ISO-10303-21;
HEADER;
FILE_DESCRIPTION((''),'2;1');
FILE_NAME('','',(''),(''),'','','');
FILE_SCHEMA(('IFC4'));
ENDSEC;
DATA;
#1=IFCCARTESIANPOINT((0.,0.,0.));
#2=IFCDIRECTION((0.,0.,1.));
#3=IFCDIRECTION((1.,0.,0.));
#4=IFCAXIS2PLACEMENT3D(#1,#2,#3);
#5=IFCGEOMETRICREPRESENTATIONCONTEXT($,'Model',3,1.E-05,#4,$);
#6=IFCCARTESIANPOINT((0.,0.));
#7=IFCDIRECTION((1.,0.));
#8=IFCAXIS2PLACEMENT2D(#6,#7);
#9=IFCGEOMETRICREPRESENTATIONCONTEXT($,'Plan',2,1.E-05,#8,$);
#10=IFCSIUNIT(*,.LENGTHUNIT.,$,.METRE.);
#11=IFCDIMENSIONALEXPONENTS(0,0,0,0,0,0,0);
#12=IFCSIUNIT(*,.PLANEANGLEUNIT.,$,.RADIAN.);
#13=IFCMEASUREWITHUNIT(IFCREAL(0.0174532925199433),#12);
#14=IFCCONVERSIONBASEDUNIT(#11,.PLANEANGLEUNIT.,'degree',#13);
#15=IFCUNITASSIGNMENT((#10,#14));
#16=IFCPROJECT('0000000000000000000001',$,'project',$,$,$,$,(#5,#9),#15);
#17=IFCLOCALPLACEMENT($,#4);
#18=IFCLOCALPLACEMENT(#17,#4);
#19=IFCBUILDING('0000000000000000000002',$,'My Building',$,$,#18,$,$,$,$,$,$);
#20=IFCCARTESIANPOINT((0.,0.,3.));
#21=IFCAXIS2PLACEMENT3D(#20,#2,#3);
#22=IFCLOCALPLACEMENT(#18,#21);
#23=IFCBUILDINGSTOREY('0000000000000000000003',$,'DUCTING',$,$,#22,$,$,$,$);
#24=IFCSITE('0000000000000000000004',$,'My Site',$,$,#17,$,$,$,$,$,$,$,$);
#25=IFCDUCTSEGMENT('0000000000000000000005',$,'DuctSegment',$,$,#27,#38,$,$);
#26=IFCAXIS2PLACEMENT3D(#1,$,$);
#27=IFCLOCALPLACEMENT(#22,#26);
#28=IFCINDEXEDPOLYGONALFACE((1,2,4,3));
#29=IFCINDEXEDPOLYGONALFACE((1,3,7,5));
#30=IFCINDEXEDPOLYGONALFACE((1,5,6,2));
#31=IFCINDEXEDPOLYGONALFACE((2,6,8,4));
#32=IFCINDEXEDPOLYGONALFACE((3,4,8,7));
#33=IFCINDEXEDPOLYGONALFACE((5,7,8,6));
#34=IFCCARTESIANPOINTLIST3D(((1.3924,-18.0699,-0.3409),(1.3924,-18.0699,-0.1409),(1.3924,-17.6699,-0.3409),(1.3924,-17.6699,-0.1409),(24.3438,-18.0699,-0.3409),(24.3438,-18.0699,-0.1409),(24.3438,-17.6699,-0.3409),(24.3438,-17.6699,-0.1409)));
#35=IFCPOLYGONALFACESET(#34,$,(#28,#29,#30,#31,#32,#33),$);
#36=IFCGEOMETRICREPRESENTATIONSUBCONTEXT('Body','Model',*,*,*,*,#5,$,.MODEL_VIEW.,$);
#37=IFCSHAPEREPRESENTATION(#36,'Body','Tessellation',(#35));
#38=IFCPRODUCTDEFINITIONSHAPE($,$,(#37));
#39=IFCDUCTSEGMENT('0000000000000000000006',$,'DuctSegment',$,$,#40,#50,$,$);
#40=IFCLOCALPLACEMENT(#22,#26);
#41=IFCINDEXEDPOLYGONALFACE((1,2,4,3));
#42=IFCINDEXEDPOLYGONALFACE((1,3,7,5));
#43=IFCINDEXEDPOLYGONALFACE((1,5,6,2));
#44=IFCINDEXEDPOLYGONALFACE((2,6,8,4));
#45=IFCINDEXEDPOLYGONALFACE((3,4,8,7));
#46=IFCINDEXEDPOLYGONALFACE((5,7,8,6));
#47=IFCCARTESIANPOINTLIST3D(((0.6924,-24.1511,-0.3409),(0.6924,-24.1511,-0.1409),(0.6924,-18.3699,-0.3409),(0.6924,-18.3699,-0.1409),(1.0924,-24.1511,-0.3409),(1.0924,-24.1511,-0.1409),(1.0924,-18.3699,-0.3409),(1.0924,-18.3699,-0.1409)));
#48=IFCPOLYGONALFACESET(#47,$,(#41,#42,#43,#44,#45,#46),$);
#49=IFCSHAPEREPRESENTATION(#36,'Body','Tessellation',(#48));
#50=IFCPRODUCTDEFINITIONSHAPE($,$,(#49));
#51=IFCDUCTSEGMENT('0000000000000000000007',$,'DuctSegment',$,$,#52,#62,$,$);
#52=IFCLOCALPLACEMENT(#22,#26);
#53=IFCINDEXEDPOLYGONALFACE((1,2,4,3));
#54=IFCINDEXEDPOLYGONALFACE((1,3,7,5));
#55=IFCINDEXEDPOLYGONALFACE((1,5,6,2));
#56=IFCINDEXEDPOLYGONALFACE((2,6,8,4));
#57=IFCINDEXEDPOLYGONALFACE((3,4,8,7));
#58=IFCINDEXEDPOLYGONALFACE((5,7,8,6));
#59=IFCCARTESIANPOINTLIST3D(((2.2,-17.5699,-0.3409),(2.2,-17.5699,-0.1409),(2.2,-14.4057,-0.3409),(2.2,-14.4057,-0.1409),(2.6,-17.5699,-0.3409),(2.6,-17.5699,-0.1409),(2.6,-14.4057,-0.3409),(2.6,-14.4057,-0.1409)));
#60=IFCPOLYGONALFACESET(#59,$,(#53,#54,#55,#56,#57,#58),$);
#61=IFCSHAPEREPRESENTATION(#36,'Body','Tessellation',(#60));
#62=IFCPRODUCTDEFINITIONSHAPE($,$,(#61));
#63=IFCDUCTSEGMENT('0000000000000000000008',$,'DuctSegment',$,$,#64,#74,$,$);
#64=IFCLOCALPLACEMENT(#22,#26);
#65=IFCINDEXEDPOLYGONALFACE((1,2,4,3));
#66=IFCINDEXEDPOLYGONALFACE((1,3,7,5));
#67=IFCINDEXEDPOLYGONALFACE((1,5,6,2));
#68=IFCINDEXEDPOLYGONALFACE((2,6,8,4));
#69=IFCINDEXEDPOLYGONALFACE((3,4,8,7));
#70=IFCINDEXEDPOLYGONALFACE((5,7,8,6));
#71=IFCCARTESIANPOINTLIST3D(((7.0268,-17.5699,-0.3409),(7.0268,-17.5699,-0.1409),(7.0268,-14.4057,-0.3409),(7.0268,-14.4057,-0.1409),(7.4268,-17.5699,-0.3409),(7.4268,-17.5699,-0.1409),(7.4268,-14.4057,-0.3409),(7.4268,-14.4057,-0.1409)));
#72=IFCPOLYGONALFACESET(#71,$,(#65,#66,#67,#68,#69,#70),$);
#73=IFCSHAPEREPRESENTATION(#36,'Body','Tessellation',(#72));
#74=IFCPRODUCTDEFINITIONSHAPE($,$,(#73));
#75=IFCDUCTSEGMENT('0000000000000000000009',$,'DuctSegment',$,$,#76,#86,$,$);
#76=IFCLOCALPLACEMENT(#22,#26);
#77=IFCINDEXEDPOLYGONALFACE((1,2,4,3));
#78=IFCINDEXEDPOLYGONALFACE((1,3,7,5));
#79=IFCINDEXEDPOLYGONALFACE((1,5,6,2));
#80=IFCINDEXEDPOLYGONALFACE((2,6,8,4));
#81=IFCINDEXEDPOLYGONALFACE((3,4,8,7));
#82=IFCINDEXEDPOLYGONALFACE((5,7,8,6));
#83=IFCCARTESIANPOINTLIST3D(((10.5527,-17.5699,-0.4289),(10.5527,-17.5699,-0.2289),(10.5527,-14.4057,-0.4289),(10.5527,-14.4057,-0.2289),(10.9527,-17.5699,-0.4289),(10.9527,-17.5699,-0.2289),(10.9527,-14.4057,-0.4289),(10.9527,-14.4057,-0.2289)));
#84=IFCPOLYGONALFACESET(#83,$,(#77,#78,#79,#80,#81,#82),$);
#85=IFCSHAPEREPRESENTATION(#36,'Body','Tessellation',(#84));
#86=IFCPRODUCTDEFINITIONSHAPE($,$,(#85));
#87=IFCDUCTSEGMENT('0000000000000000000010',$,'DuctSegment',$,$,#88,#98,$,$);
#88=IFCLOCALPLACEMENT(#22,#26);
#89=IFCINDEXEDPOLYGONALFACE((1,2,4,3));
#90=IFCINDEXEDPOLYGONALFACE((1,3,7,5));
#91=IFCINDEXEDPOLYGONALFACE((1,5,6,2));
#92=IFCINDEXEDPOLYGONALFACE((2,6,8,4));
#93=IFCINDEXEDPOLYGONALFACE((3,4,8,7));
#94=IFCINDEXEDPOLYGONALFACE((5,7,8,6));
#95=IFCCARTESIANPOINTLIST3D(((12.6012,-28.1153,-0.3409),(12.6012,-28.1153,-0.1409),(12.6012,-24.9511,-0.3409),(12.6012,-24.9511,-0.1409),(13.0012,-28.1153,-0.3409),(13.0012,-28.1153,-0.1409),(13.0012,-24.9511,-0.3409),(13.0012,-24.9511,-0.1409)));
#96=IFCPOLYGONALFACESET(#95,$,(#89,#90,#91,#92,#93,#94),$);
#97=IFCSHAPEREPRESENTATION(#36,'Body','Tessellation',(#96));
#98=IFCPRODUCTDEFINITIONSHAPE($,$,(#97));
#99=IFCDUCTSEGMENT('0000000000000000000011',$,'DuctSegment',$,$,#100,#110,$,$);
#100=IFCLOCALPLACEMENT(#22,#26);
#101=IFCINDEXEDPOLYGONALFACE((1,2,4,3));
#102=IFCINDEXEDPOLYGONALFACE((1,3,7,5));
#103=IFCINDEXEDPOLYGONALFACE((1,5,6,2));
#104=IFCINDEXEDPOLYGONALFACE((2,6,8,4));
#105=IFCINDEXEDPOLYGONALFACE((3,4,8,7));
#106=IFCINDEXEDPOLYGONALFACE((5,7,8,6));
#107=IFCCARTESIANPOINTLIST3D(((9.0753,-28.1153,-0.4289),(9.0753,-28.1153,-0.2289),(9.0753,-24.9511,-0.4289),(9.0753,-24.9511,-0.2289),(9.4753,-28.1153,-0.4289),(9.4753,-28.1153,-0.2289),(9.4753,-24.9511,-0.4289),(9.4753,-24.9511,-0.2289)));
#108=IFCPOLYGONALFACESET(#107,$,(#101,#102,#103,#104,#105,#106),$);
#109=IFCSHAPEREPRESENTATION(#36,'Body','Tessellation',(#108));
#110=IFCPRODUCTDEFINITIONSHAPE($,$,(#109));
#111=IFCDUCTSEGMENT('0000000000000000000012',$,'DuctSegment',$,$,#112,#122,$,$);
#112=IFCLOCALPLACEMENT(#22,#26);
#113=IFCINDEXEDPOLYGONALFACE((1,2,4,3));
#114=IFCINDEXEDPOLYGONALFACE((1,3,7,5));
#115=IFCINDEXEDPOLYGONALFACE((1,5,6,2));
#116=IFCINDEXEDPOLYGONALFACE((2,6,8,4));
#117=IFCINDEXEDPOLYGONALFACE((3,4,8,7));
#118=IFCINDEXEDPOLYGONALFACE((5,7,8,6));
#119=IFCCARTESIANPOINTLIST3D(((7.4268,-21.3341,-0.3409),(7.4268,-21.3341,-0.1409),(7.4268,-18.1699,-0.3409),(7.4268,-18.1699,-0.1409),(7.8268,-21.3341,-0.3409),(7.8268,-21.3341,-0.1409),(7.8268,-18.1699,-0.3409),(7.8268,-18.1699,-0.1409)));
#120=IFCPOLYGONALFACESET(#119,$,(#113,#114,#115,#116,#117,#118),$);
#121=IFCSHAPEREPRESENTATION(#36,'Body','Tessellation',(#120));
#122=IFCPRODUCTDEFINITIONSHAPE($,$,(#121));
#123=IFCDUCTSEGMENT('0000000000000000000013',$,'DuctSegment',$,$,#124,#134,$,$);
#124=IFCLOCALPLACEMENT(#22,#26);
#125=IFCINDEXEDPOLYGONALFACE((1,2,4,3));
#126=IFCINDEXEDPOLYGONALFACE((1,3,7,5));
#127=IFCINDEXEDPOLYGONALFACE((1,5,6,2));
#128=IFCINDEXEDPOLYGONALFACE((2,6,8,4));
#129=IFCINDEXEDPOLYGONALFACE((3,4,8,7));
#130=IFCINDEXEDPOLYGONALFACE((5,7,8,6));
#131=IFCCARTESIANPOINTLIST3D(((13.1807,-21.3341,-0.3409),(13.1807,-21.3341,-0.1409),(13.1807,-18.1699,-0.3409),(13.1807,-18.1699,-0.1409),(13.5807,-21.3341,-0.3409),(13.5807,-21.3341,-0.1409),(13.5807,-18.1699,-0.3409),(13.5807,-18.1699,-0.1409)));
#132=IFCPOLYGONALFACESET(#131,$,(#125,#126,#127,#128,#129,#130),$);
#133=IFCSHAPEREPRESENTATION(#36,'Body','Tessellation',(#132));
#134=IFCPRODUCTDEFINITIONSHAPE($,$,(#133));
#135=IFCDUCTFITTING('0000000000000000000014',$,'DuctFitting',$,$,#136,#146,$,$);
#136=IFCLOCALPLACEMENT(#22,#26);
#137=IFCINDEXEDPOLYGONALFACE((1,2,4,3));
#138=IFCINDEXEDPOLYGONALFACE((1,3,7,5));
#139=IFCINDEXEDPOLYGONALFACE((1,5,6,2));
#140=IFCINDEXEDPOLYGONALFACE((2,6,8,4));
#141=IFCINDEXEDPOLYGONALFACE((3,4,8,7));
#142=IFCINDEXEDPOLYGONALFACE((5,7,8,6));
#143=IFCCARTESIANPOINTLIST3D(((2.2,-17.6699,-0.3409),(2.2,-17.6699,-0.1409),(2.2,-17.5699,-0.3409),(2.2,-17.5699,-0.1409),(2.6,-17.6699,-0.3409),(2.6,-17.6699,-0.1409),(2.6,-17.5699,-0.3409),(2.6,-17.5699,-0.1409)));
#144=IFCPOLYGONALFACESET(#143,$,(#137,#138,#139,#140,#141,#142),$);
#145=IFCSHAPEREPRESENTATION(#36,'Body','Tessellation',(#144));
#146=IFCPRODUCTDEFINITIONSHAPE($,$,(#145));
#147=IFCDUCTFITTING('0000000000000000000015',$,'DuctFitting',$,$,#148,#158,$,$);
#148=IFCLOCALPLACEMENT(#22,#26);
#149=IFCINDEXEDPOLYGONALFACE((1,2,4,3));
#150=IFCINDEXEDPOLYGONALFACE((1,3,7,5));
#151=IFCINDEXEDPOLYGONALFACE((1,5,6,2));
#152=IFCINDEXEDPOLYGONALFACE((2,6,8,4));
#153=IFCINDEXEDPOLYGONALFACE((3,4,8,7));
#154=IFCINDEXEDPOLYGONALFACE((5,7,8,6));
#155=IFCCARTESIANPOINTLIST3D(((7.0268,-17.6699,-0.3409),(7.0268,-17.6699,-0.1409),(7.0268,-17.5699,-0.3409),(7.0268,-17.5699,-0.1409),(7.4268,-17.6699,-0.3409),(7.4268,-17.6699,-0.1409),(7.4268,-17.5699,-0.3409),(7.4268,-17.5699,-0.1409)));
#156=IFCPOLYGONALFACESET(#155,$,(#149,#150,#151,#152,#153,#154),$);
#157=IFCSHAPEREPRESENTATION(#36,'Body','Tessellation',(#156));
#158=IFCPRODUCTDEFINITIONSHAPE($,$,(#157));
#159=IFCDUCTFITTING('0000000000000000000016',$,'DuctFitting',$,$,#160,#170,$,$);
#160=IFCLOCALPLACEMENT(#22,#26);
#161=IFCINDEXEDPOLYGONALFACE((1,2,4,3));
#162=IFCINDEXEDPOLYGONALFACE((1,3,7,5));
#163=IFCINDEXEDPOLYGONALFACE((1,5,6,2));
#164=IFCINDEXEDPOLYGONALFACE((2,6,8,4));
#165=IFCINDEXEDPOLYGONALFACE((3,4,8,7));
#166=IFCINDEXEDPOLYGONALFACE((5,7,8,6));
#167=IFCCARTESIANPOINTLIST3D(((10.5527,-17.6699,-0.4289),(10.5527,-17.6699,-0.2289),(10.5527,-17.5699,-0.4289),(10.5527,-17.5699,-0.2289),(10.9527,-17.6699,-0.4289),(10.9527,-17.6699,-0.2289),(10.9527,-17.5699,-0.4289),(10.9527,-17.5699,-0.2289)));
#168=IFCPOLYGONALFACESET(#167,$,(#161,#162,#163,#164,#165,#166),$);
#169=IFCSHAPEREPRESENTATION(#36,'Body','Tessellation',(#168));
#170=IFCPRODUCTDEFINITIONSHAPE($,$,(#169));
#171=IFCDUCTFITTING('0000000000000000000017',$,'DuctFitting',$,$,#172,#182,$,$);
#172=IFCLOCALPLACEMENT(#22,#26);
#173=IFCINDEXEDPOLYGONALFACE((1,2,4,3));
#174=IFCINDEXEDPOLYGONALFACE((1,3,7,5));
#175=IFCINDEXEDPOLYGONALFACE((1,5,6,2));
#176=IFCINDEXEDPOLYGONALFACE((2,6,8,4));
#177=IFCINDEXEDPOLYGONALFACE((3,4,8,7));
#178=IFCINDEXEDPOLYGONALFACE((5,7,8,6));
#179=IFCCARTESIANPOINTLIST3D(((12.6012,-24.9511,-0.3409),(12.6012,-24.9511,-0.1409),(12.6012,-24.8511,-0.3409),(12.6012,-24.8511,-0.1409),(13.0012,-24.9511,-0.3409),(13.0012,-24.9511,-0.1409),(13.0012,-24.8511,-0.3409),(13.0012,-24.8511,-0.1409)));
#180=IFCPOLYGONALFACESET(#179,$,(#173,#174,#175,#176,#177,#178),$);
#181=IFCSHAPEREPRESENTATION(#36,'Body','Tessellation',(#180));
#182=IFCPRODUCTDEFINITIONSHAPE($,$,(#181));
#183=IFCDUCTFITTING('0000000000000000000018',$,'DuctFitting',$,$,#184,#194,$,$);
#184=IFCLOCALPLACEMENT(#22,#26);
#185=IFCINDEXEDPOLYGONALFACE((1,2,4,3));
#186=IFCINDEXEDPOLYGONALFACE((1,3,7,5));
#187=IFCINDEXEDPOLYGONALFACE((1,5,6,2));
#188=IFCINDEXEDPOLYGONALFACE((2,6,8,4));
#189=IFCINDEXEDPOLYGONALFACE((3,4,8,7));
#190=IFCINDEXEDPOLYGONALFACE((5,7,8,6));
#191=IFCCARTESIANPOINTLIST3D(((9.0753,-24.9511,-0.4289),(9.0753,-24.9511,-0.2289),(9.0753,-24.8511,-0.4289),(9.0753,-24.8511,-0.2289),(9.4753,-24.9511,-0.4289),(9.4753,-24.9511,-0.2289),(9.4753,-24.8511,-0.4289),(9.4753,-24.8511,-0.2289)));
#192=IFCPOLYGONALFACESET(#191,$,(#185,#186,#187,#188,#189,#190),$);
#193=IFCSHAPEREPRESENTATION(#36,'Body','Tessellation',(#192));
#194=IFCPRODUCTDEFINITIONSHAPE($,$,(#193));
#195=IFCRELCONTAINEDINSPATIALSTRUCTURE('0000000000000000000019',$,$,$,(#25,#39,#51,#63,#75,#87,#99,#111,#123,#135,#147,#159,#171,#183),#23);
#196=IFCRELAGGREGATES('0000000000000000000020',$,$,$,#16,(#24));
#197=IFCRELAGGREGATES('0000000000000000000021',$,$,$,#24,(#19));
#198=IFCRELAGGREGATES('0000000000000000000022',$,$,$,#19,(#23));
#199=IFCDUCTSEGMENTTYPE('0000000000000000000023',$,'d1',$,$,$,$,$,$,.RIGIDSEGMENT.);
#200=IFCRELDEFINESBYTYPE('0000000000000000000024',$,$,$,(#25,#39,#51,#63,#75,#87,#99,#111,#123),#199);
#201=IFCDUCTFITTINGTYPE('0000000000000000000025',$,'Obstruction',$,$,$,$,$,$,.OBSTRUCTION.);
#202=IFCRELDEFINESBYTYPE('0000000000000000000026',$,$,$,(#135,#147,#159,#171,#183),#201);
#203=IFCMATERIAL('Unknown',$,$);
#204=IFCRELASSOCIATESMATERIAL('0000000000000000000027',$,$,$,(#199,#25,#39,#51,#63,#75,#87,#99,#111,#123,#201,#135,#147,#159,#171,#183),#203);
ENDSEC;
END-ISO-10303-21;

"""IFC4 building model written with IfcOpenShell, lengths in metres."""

from ifc_helpers import new_model, entity, si_unit, converted_unit, frame, origin_with_axes, origin_2d_with_axis, place, context, subcontext, project, spatial, rectangle, extrude, material, material_profile, profile_set, profile_usage, type_object, element, save


model = new_model("IFC4")

# Units and contexts
model_context = context("Model", 3, precision=1e-05, world=origin_with_axes())
plan_context = context("Plan", 2, precision=1e-05, world=origin_2d_with_axis())
body_context = subcontext(model_context, "Body", "Model", "MODEL_VIEW")
ifc_project = project(units=[si_unit("LENGTHUNIT", "METRE"), converted_unit("PLANEANGLEUNIT", "degree", entity("IfcReal", 0.0174532925199433), si_unit("PLANEANGLEUNIT", "RADIAN"), dimensions=[0, 0, 0, 0, 0, 0, 0])], contexts=[model_context, plan_context])

# Site, building, storey
site_placement = place(None, origin_with_axes())
site = spatial("IfcSite", under=ifc_project, at=site_placement, Name="My Site")
building_placement = place(site_placement, origin_with_axes())
building = spatial("IfcBuilding", under=site, at=building_placement, Name="My Building")
storey_placement = place(building_placement, frame((0.0, 0.0, 3.0), z_axis=(0.0, 0.0, 1.0), x_axis=(1.0, 0.0, 0.0)))
storey = spatial("IfcBuildingStorey", under=building, at=storey_placement, Name="DUCTING")

# Duct segments
ifc_material = material(Name="Unknown")
ifc_material_profile_1 = material_profile(ifc_material, rectangle(XDim=0.4, YDim=0.2))
ifc_profile_set_1 = profile_set([ifc_material_profile_1])
ifc_profile_usage_1 = profile_usage(ifc_profile_set_1, cardinal=5)
duct_segment_type = type_object("IfcDuctSegmentType", Name="d1", PredefinedType="RIGIDSEGMENT", material=ifc_profile_set_1)
duct_segment_1_placement = place(storey_placement, frame((1.3924, -17.8699, -0.2409), z_axis=(1.0, 0.0, 0.0), x_axis=(0.0, 1.0, 0.0)))
element("IfcDuctSegment", 1, at=duct_segment_1_placement, inside=storey, type_object=duct_segment_type, material=ifc_profile_usage_1, Name="DuctSegment", context=body_context, shape_type="SweptSolid", body=[
    extrude(rectangle(XDim=0.4, YDim=0.2), origin_with_axes(), (0.0, 0.0, 1.0), 22.9514),
])
ifc_profile_usage_2 = profile_usage(ifc_profile_set_1, cardinal=5)
duct_segment_2_placement = place(storey_placement, frame((0.8924, -24.1511, -0.2409), z_axis=(0.0, 1.0, 0.0), x_axis=(1.0, 0.0, 0.0)))
element("IfcDuctSegment", 2, at=duct_segment_2_placement, inside=storey, type_object=duct_segment_type, material=ifc_profile_usage_2, Name="DuctSegment", context=body_context, shape_type="SweptSolid", body=[
    extrude(rectangle(XDim=0.4, YDim=0.2), origin_with_axes(), (0.0, 0.0, 1.0), 5.7812),
])
ifc_profile_usage_3 = profile_usage(ifc_profile_set_1, cardinal=5)
duct_segment_3_placement = place(storey_placement, frame((2.4, -17.5699, -0.2409), z_axis=(0.0, 1.0, 0.0), x_axis=(-1.0, 0.0, 0.0)))
element("IfcDuctSegment", 3, at=duct_segment_3_placement, inside=storey, type_object=duct_segment_type, material=ifc_profile_usage_3, Name="DuctSegment", context=body_context, shape_type="SweptSolid", body=[
    extrude(rectangle(XDim=0.4, YDim=0.2), origin_with_axes(), (0.0, 0.0, 1.0), 3.1642),
])
ifc_profile_usage_4 = profile_usage(ifc_profile_set_1, cardinal=5)
duct_segment_4_placement = place(storey_placement, frame((7.2268, -17.5699, -0.2409), z_axis=(0.0, 1.0, 0.0), x_axis=(-1.0, 0.0, 0.0)))
element("IfcDuctSegment", 4, at=duct_segment_4_placement, inside=storey, type_object=duct_segment_type, material=ifc_profile_usage_4, Name="DuctSegment", context=body_context, shape_type="SweptSolid", body=[
    extrude(rectangle(XDim=0.4, YDim=0.2), origin_with_axes(), (0.0, 0.0, 1.0), 3.1642),
])
ifc_profile_usage_5 = profile_usage(ifc_profile_set_1, cardinal=5)
duct_segment_5_placement = place(storey_placement, frame((10.7527, -17.5699, -0.3289), z_axis=(0.0, 1.0, 0.0), x_axis=(-1.0, 0.0, 0.0)))
element("IfcDuctSegment", 5, at=duct_segment_5_placement, inside=storey, type_object=duct_segment_type, material=ifc_profile_usage_5, Name="DuctSegment", context=body_context, shape_type="SweptSolid", body=[
    extrude(rectangle(XDim=0.4, YDim=0.2), origin_with_axes(), (0.0, 0.0, 1.0), 3.1642),
])
ifc_profile_usage_6 = profile_usage(ifc_profile_set_1, cardinal=5)
duct_segment_6_placement = place(storey_placement, frame((12.8012, -24.9511, -0.2409), z_axis=(0.0, -1.0, 0.0), x_axis=(1.0, 0.0, 0.0)))
element("IfcDuctSegment", 6, at=duct_segment_6_placement, inside=storey, type_object=duct_segment_type, material=ifc_profile_usage_6, Name="DuctSegment", context=body_context, shape_type="SweptSolid", body=[
    extrude(rectangle(XDim=0.4, YDim=0.2), origin_with_axes(), (0.0, 0.0, 1.0), 3.1642),
])
ifc_profile_usage_7 = profile_usage(ifc_profile_set_1, cardinal=5)
duct_segment_7_placement = place(storey_placement, frame((9.2753, -24.9511, -0.3289), z_axis=(0.0, -1.0, 0.0), x_axis=(1.0, 0.0, 0.0)))
element("IfcDuctSegment", 7, at=duct_segment_7_placement, inside=storey, type_object=duct_segment_type, material=ifc_profile_usage_7, Name="DuctSegment", context=body_context, shape_type="SweptSolid", body=[
    extrude(rectangle(XDim=0.4, YDim=0.2), origin_with_axes(), (0.0, 0.0, 1.0), 3.1642),
])
ifc_profile_usage_8 = profile_usage(ifc_profile_set_1, cardinal=5)
duct_segment_8_placement = place(storey_placement, frame((7.6268, -18.1699, -0.2409), z_axis=(0.0, -1.0, 0.0), x_axis=(1.0, 0.0, 0.0)))
element("IfcDuctSegment", 8, at=duct_segment_8_placement, inside=storey, type_object=duct_segment_type, material=ifc_profile_usage_8, Name="DuctSegment", context=body_context, shape_type="SweptSolid", body=[
    extrude(rectangle(XDim=0.4, YDim=0.2), origin_with_axes(), (0.0, 0.0, 1.0), 3.1642),
])
ifc_profile_usage_9 = profile_usage(ifc_profile_set_1, cardinal=5)
duct_segment_9_placement = place(storey_placement, frame((13.3807, -18.1699, -0.2409), z_axis=(0.0, -1.0, 0.0), x_axis=(1.0, 0.0, 0.0)))
element("IfcDuctSegment", 9, at=duct_segment_9_placement, inside=storey, type_object=duct_segment_type, material=ifc_profile_usage_9, Name="DuctSegment", context=body_context, shape_type="SweptSolid", body=[
    extrude(rectangle(XDim=0.4, YDim=0.2), origin_with_axes(), (0.0, 0.0, 1.0), 3.1642),
])

# Duct fittings
ifc_material_profile_2 = material_profile(ifc_material, rectangle(XDim=0.4, YDim=0.2))
ifc_profile_set_2 = profile_set([ifc_material_profile_2])
ifc_profile_usage_10 = profile_usage(ifc_profile_set_2, cardinal=5)
duct_fitting_type = type_object("IfcDuctFittingType", Name="Obstruction", PredefinedType="OBSTRUCTION", material=ifc_profile_set_2)
duct_fitting_1_placement = place(storey_placement, frame((2.4, -17.6699, -0.2409), z_axis=(0.0, 1.0, 0.0), x_axis=(-1.0, 0.0, 0.0)))
element("IfcDuctFitting", 10, at=duct_fitting_1_placement, inside=storey, type_object=duct_fitting_type, material=ifc_profile_usage_10, Name="DuctFitting", context=body_context, shape_type="SweptSolid", body=[
    extrude(rectangle(XDim=0.4, YDim=0.2), origin_with_axes(), (0.0, 0.0, 1.0), 0.1),
])
ifc_profile_usage_11 = profile_usage(ifc_profile_set_2, cardinal=5)
duct_fitting_2_placement = place(storey_placement, frame((7.2268, -17.6699, -0.2409), z_axis=(0.0, 1.0, 0.0), x_axis=(-1.0, 0.0, 0.0)))
element("IfcDuctFitting", 11, at=duct_fitting_2_placement, inside=storey, type_object=duct_fitting_type, material=ifc_profile_usage_11, Name="DuctFitting", context=body_context, shape_type="SweptSolid", body=[
    extrude(rectangle(XDim=0.4, YDim=0.2), origin_with_axes(), (0.0, 0.0, 1.0), 0.1),
])
ifc_profile_usage_12 = profile_usage(ifc_profile_set_2, cardinal=5)
duct_fitting_3_placement = place(storey_placement, frame((10.7527, -17.6699, -0.3289), z_axis=(0.0, 1.0, 0.0), x_axis=(-1.0, 0.0, 0.0)))
element("IfcDuctFitting", 12, at=duct_fitting_3_placement, inside=storey, type_object=duct_fitting_type, material=ifc_profile_usage_12, Name="DuctFitting", context=body_context, shape_type="SweptSolid", body=[
    extrude(rectangle(XDim=0.4, YDim=0.2), origin_with_axes(), (0.0, 0.0, 1.0), 0.1),
])
ifc_profile_usage_13 = profile_usage(ifc_profile_set_2, cardinal=5)
duct_fitting_4_placement = place(storey_placement, frame((12.8012, -24.8511, -0.2409), z_axis=(0.0, -1.0, 0.0), x_axis=(1.0, 0.0, 0.0)))
element("IfcDuctFitting", 13, at=duct_fitting_4_placement, inside=storey, type_object=duct_fitting_type, material=ifc_profile_usage_13, Name="DuctFitting", context=body_context, shape_type="SweptSolid", body=[
    extrude(rectangle(XDim=0.4, YDim=0.2), origin_with_axes(), (0.0, 0.0, 1.0), 0.1),
])
ifc_profile_usage_14 = profile_usage(ifc_profile_set_2, cardinal=5)
duct_fitting_5_placement = place(storey_placement, frame((9.2753, -24.8511, -0.3289), z_axis=(0.0, -1.0, 0.0), x_axis=(1.0, 0.0, 0.0)))
element("IfcDuctFitting", 14, at=duct_fitting_5_placement, inside=storey, type_object=duct_fitting_type, material=ifc_profile_usage_14, Name="DuctFitting", context=body_context, shape_type="SweptSolid", body=[
    extrude(rectangle(XDim=0.4, YDim=0.2), origin_with_axes(), (0.0, 0.0, 1.0), 0.1),
])

save(model, "model.ifc")
